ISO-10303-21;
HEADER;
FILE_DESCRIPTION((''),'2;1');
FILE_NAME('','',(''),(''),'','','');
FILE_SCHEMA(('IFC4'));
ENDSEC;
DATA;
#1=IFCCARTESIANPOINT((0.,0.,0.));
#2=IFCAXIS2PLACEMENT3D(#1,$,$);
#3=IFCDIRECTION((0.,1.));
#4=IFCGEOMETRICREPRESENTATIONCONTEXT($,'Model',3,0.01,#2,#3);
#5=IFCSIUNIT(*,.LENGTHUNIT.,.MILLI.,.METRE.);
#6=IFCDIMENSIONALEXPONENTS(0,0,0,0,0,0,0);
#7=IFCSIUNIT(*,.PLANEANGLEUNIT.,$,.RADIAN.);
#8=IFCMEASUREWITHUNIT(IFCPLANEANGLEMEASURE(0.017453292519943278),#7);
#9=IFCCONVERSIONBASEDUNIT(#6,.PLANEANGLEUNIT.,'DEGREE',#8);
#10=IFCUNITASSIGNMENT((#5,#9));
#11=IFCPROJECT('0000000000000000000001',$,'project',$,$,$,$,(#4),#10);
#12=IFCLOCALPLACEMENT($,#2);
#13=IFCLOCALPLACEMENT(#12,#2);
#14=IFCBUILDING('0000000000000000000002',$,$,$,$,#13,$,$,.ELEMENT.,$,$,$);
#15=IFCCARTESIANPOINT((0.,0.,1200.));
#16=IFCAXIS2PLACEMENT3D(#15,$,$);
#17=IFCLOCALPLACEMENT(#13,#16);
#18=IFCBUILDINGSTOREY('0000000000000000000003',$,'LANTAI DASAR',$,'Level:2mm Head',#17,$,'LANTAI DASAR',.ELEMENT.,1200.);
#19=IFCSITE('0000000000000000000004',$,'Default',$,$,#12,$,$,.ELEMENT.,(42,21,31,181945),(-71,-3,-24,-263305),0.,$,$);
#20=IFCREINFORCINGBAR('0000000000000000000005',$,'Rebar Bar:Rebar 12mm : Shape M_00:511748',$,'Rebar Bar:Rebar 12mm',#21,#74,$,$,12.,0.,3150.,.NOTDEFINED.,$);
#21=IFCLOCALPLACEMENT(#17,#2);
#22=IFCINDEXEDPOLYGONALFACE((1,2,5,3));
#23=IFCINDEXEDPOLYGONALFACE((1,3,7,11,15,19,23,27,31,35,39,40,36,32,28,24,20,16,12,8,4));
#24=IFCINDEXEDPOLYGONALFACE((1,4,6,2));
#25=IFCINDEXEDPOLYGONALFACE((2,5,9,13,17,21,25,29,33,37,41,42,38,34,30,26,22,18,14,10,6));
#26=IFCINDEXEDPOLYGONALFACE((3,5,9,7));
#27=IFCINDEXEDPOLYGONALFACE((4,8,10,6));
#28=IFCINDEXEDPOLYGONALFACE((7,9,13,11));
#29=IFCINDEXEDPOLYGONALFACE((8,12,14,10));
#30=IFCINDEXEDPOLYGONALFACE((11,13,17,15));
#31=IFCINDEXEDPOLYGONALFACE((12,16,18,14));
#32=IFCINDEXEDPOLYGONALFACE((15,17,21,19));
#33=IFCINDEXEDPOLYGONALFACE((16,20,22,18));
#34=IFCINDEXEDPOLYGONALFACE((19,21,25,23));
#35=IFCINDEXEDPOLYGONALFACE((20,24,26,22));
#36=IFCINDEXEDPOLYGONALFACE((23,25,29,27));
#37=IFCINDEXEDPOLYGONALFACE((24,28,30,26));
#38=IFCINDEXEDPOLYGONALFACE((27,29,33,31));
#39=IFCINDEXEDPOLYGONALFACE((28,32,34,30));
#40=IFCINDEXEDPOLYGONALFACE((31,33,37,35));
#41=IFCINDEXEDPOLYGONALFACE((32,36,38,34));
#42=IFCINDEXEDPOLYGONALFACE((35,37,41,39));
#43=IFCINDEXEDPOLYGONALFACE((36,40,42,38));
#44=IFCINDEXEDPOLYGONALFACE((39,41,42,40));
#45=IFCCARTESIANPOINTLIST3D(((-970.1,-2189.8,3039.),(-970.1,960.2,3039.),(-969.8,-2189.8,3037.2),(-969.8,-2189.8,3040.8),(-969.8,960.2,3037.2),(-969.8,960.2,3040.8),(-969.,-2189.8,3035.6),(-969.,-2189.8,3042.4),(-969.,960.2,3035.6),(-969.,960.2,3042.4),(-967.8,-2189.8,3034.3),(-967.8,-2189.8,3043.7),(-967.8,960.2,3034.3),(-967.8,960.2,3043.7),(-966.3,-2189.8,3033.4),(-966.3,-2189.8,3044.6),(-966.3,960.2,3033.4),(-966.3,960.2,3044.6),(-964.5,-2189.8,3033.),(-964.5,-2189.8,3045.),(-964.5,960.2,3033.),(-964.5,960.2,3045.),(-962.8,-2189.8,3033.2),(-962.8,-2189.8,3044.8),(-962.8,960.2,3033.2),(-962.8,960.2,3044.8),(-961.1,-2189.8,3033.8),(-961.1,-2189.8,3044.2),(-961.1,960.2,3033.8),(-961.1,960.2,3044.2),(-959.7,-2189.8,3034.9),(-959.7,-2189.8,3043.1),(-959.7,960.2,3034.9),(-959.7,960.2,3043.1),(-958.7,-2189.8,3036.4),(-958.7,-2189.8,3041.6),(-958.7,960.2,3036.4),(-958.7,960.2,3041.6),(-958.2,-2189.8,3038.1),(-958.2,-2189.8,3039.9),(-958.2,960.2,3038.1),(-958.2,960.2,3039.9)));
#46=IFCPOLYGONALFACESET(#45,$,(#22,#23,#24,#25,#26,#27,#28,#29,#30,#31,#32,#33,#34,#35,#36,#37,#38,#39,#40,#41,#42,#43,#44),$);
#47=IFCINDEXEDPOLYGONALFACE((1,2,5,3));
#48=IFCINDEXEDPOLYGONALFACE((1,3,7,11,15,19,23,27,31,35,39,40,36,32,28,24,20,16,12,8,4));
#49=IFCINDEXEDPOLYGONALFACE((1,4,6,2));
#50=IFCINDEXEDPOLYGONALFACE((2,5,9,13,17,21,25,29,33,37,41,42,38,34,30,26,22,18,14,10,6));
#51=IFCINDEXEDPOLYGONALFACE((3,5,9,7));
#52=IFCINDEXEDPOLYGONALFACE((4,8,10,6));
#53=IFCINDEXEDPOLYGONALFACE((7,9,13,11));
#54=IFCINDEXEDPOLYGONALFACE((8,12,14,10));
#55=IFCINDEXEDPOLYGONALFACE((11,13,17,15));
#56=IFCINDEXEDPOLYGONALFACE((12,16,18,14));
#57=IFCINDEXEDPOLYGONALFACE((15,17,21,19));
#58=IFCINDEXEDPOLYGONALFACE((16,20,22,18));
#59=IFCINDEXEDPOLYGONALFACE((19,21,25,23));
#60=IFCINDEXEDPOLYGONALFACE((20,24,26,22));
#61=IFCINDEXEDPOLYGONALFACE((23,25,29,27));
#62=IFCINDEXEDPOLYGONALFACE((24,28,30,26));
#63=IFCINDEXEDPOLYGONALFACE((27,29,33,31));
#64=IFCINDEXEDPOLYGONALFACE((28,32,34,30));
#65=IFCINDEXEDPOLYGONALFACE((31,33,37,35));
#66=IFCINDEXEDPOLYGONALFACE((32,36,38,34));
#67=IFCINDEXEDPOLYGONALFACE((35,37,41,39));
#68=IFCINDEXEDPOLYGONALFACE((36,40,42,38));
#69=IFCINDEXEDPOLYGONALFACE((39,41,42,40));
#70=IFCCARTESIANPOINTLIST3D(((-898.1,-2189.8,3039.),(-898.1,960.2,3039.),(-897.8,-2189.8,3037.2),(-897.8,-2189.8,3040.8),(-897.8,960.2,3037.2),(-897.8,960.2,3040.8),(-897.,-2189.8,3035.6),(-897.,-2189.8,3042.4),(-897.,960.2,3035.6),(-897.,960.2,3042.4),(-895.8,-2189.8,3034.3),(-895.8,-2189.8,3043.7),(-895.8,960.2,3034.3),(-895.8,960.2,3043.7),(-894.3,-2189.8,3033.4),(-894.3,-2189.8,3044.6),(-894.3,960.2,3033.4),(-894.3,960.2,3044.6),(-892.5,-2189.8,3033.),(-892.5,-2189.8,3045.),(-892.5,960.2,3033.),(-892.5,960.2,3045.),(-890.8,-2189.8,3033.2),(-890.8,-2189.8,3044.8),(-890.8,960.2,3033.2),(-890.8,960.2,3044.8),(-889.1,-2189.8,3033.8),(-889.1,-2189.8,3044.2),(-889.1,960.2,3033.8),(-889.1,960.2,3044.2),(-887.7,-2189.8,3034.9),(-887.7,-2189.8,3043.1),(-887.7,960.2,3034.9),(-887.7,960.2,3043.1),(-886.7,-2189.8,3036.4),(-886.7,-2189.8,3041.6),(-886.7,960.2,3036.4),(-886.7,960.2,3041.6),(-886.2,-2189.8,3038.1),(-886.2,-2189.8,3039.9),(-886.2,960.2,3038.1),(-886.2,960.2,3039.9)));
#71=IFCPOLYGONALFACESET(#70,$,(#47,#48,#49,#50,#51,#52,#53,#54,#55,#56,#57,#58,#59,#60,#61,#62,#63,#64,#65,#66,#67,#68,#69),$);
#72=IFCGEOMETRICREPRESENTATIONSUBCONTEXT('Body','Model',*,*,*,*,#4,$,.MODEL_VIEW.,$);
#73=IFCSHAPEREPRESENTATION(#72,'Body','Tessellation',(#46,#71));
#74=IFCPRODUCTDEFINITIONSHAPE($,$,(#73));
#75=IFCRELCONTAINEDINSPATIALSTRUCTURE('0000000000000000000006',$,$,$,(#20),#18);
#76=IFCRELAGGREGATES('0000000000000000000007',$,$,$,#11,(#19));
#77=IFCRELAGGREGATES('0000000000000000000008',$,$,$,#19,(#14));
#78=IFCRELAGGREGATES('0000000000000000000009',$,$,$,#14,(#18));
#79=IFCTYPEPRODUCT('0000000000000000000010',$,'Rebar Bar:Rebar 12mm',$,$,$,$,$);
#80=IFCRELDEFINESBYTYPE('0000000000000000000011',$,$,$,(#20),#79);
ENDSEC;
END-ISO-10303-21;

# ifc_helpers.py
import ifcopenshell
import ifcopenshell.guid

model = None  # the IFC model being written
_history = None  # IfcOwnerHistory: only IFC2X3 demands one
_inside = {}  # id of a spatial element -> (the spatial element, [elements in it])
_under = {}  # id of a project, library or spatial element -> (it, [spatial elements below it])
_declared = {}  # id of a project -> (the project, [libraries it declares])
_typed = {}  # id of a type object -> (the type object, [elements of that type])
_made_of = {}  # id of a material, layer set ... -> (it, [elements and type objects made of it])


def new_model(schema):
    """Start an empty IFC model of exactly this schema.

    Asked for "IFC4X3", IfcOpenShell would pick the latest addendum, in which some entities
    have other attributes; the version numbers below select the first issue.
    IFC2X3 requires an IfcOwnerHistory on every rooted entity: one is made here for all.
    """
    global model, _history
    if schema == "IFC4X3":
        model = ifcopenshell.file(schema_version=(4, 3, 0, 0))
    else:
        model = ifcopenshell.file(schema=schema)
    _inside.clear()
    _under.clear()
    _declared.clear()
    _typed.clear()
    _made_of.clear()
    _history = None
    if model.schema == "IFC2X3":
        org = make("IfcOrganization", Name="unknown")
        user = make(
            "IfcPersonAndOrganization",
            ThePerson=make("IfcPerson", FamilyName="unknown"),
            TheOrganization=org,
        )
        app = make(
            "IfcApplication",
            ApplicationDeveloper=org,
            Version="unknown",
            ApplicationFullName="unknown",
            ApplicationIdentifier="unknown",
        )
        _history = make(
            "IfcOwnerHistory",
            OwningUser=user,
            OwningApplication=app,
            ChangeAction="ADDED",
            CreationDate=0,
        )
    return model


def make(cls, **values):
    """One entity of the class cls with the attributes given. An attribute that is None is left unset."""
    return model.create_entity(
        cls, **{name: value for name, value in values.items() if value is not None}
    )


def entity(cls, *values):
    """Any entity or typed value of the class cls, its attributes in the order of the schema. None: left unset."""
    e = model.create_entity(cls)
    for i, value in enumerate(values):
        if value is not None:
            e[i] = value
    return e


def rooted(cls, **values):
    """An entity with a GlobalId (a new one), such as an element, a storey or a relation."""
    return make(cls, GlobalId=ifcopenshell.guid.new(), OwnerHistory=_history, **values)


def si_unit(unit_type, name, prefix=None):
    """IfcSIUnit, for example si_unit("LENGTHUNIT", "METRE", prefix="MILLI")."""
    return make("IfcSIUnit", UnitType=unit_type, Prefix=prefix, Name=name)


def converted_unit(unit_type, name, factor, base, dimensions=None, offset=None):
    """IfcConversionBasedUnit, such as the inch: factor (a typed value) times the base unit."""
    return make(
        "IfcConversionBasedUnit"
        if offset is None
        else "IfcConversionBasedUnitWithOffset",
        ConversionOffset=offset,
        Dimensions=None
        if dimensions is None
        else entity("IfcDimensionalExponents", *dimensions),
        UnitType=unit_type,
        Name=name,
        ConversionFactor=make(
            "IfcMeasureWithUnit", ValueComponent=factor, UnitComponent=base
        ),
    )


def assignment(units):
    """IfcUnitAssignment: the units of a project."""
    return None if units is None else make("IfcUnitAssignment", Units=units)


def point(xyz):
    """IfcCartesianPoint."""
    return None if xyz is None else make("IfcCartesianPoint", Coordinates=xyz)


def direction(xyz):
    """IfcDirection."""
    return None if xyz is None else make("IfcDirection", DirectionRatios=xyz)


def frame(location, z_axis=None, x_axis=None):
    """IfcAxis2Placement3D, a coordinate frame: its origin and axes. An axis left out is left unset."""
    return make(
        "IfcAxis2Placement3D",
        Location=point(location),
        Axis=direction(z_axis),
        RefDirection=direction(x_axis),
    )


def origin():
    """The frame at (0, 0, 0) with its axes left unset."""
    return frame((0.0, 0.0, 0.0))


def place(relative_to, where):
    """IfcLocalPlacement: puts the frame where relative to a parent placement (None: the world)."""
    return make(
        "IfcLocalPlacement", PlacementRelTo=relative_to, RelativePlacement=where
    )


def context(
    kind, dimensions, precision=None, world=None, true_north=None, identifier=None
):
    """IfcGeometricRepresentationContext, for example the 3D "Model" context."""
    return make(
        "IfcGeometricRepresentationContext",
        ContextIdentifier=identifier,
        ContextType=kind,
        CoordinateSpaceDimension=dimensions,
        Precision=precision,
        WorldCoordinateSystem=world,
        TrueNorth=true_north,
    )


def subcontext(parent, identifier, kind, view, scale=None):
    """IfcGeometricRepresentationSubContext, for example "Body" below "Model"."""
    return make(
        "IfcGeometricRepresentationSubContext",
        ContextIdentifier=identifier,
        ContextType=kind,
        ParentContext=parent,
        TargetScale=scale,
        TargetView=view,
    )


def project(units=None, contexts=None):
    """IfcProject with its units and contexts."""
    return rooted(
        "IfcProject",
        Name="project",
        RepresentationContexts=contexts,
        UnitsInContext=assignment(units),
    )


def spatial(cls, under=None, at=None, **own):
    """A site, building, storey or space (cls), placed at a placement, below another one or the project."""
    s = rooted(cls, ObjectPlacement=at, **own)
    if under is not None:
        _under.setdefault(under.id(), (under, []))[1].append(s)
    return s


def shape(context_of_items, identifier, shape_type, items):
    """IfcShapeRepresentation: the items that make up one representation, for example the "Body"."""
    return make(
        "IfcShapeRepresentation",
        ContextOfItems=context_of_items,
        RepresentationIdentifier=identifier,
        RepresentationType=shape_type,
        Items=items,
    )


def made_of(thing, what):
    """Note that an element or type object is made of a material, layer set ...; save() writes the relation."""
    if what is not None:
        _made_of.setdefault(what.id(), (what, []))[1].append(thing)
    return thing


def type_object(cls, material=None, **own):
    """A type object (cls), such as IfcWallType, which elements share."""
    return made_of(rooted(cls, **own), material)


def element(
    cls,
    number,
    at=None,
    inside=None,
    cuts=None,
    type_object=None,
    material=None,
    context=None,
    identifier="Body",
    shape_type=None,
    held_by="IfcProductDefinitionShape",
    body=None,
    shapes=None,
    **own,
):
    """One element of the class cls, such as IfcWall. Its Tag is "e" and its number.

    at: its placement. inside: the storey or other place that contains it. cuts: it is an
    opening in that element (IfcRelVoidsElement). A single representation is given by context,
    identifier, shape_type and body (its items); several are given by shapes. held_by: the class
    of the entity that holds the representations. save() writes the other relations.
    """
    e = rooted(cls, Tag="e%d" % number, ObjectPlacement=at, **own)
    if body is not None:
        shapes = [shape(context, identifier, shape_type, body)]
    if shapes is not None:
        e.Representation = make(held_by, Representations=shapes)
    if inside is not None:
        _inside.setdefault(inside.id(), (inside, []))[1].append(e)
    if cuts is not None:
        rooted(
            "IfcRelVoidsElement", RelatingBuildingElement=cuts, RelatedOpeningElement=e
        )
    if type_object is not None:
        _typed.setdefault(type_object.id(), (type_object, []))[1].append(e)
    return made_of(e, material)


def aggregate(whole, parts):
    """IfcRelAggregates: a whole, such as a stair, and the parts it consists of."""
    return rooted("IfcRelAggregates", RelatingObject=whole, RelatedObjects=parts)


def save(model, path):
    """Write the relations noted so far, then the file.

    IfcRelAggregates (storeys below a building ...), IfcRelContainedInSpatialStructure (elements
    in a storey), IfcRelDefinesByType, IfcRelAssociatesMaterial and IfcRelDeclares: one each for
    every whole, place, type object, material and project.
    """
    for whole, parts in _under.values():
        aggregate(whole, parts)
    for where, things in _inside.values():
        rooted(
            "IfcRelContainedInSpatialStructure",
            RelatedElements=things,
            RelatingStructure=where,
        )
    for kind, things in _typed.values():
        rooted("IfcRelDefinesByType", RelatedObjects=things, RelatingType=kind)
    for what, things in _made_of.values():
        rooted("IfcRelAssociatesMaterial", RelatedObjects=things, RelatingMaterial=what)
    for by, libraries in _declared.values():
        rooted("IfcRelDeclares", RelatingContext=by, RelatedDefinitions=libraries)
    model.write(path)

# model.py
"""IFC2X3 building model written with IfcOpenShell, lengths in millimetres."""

from ifc_helpers import new_model, entity, si_unit, converted_unit, direction, frame, origin, place, context, subcontext, project, spatial, type_object, element, save


model = new_model("IFC2X3")

# Units and contexts
model_context = context("Model", 3, precision=0.01, world=origin(), true_north=direction((0.0, 1.0)))
body_context = subcontext(model_context, "Body", "Model", "MODEL_VIEW")
ifc_project = project(units=[si_unit("LENGTHUNIT", "METRE", prefix="MILLI"), converted_unit("PLANEANGLEUNIT", "DEGREE", entity("IfcPlaneAngleMeasure", 0.017453292519943278), si_unit("PLANEANGLEUNIT", "RADIAN"), dimensions=[0, 0, 0, 0, 0, 0, 0])], contexts=[model_context])

# Site, building, storey
site_placement = place(None, origin())
site = spatial("IfcSite", under=ifc_project, at=site_placement, Name="Default", CompositionType="ELEMENT", RefLatitude=(42, 21, 31, 181945), RefLongitude=(-71, -3, -24, -263305), RefElevation=0.0)
building_placement = place(site_placement, origin())
building = spatial("IfcBuilding", under=site, at=building_placement, CompositionType="ELEMENT")
storey_placement = place(building_placement, frame((0.0, 0.0, 1200.0)))
storey = spatial("IfcBuildingStorey", under=building, at=storey_placement, Name="LANTAI DASAR", ObjectType="Level:2mm Head", LongName="LANTAI DASAR", CompositionType="ELEMENT", Elevation=1200.0)

# Reinforcing bar
type_product_1 = type_object("IfcTypeProduct", Name="Rebar Bar:Rebar 12mm")
reinforcing_bar_1_placement = place(storey_placement, origin())
element("IfcReinforcingBar", 1, at=reinforcing_bar_1_placement, inside=storey, type_object=type_product_1, Name="Rebar Bar:Rebar 12mm : Shape M_00:511748", ObjectType="Rebar Bar:Rebar 12mm", BarLength=3150.0, BarRole="NOTDEFINED", CrossSectionArea=0.0, NominalDiameter=12.0, context=body_context, shape_type="AdvancedSweptSolid", body=[
    entity("IfcSweptDiskSolid", entity("IfcCompositeCurve", [entity("IfcCompositeCurveSegment", "CONTINUOUS", True, entity("IfcPolyline", [entity("IfcCartesianPoint", [-964.1, 960.2, 3039.0]), entity("IfcCartesianPoint", [-964.1, -2189.8, 3039.0])]))], False), 6.0, None, 0.0, 1.0),
    entity("IfcSweptDiskSolid", entity("IfcCompositeCurve", [entity("IfcCompositeCurveSegment", "CONTINUOUS", True, entity("IfcPolyline", [entity("IfcCartesianPoint", [-892.1, 960.2, 3039.0]), entity("IfcCartesianPoint", [-892.1, -2189.8, 3039.0])]))], False), 6.0, None, 0.0, 1.0),
])

save(model, "model.ifc")
